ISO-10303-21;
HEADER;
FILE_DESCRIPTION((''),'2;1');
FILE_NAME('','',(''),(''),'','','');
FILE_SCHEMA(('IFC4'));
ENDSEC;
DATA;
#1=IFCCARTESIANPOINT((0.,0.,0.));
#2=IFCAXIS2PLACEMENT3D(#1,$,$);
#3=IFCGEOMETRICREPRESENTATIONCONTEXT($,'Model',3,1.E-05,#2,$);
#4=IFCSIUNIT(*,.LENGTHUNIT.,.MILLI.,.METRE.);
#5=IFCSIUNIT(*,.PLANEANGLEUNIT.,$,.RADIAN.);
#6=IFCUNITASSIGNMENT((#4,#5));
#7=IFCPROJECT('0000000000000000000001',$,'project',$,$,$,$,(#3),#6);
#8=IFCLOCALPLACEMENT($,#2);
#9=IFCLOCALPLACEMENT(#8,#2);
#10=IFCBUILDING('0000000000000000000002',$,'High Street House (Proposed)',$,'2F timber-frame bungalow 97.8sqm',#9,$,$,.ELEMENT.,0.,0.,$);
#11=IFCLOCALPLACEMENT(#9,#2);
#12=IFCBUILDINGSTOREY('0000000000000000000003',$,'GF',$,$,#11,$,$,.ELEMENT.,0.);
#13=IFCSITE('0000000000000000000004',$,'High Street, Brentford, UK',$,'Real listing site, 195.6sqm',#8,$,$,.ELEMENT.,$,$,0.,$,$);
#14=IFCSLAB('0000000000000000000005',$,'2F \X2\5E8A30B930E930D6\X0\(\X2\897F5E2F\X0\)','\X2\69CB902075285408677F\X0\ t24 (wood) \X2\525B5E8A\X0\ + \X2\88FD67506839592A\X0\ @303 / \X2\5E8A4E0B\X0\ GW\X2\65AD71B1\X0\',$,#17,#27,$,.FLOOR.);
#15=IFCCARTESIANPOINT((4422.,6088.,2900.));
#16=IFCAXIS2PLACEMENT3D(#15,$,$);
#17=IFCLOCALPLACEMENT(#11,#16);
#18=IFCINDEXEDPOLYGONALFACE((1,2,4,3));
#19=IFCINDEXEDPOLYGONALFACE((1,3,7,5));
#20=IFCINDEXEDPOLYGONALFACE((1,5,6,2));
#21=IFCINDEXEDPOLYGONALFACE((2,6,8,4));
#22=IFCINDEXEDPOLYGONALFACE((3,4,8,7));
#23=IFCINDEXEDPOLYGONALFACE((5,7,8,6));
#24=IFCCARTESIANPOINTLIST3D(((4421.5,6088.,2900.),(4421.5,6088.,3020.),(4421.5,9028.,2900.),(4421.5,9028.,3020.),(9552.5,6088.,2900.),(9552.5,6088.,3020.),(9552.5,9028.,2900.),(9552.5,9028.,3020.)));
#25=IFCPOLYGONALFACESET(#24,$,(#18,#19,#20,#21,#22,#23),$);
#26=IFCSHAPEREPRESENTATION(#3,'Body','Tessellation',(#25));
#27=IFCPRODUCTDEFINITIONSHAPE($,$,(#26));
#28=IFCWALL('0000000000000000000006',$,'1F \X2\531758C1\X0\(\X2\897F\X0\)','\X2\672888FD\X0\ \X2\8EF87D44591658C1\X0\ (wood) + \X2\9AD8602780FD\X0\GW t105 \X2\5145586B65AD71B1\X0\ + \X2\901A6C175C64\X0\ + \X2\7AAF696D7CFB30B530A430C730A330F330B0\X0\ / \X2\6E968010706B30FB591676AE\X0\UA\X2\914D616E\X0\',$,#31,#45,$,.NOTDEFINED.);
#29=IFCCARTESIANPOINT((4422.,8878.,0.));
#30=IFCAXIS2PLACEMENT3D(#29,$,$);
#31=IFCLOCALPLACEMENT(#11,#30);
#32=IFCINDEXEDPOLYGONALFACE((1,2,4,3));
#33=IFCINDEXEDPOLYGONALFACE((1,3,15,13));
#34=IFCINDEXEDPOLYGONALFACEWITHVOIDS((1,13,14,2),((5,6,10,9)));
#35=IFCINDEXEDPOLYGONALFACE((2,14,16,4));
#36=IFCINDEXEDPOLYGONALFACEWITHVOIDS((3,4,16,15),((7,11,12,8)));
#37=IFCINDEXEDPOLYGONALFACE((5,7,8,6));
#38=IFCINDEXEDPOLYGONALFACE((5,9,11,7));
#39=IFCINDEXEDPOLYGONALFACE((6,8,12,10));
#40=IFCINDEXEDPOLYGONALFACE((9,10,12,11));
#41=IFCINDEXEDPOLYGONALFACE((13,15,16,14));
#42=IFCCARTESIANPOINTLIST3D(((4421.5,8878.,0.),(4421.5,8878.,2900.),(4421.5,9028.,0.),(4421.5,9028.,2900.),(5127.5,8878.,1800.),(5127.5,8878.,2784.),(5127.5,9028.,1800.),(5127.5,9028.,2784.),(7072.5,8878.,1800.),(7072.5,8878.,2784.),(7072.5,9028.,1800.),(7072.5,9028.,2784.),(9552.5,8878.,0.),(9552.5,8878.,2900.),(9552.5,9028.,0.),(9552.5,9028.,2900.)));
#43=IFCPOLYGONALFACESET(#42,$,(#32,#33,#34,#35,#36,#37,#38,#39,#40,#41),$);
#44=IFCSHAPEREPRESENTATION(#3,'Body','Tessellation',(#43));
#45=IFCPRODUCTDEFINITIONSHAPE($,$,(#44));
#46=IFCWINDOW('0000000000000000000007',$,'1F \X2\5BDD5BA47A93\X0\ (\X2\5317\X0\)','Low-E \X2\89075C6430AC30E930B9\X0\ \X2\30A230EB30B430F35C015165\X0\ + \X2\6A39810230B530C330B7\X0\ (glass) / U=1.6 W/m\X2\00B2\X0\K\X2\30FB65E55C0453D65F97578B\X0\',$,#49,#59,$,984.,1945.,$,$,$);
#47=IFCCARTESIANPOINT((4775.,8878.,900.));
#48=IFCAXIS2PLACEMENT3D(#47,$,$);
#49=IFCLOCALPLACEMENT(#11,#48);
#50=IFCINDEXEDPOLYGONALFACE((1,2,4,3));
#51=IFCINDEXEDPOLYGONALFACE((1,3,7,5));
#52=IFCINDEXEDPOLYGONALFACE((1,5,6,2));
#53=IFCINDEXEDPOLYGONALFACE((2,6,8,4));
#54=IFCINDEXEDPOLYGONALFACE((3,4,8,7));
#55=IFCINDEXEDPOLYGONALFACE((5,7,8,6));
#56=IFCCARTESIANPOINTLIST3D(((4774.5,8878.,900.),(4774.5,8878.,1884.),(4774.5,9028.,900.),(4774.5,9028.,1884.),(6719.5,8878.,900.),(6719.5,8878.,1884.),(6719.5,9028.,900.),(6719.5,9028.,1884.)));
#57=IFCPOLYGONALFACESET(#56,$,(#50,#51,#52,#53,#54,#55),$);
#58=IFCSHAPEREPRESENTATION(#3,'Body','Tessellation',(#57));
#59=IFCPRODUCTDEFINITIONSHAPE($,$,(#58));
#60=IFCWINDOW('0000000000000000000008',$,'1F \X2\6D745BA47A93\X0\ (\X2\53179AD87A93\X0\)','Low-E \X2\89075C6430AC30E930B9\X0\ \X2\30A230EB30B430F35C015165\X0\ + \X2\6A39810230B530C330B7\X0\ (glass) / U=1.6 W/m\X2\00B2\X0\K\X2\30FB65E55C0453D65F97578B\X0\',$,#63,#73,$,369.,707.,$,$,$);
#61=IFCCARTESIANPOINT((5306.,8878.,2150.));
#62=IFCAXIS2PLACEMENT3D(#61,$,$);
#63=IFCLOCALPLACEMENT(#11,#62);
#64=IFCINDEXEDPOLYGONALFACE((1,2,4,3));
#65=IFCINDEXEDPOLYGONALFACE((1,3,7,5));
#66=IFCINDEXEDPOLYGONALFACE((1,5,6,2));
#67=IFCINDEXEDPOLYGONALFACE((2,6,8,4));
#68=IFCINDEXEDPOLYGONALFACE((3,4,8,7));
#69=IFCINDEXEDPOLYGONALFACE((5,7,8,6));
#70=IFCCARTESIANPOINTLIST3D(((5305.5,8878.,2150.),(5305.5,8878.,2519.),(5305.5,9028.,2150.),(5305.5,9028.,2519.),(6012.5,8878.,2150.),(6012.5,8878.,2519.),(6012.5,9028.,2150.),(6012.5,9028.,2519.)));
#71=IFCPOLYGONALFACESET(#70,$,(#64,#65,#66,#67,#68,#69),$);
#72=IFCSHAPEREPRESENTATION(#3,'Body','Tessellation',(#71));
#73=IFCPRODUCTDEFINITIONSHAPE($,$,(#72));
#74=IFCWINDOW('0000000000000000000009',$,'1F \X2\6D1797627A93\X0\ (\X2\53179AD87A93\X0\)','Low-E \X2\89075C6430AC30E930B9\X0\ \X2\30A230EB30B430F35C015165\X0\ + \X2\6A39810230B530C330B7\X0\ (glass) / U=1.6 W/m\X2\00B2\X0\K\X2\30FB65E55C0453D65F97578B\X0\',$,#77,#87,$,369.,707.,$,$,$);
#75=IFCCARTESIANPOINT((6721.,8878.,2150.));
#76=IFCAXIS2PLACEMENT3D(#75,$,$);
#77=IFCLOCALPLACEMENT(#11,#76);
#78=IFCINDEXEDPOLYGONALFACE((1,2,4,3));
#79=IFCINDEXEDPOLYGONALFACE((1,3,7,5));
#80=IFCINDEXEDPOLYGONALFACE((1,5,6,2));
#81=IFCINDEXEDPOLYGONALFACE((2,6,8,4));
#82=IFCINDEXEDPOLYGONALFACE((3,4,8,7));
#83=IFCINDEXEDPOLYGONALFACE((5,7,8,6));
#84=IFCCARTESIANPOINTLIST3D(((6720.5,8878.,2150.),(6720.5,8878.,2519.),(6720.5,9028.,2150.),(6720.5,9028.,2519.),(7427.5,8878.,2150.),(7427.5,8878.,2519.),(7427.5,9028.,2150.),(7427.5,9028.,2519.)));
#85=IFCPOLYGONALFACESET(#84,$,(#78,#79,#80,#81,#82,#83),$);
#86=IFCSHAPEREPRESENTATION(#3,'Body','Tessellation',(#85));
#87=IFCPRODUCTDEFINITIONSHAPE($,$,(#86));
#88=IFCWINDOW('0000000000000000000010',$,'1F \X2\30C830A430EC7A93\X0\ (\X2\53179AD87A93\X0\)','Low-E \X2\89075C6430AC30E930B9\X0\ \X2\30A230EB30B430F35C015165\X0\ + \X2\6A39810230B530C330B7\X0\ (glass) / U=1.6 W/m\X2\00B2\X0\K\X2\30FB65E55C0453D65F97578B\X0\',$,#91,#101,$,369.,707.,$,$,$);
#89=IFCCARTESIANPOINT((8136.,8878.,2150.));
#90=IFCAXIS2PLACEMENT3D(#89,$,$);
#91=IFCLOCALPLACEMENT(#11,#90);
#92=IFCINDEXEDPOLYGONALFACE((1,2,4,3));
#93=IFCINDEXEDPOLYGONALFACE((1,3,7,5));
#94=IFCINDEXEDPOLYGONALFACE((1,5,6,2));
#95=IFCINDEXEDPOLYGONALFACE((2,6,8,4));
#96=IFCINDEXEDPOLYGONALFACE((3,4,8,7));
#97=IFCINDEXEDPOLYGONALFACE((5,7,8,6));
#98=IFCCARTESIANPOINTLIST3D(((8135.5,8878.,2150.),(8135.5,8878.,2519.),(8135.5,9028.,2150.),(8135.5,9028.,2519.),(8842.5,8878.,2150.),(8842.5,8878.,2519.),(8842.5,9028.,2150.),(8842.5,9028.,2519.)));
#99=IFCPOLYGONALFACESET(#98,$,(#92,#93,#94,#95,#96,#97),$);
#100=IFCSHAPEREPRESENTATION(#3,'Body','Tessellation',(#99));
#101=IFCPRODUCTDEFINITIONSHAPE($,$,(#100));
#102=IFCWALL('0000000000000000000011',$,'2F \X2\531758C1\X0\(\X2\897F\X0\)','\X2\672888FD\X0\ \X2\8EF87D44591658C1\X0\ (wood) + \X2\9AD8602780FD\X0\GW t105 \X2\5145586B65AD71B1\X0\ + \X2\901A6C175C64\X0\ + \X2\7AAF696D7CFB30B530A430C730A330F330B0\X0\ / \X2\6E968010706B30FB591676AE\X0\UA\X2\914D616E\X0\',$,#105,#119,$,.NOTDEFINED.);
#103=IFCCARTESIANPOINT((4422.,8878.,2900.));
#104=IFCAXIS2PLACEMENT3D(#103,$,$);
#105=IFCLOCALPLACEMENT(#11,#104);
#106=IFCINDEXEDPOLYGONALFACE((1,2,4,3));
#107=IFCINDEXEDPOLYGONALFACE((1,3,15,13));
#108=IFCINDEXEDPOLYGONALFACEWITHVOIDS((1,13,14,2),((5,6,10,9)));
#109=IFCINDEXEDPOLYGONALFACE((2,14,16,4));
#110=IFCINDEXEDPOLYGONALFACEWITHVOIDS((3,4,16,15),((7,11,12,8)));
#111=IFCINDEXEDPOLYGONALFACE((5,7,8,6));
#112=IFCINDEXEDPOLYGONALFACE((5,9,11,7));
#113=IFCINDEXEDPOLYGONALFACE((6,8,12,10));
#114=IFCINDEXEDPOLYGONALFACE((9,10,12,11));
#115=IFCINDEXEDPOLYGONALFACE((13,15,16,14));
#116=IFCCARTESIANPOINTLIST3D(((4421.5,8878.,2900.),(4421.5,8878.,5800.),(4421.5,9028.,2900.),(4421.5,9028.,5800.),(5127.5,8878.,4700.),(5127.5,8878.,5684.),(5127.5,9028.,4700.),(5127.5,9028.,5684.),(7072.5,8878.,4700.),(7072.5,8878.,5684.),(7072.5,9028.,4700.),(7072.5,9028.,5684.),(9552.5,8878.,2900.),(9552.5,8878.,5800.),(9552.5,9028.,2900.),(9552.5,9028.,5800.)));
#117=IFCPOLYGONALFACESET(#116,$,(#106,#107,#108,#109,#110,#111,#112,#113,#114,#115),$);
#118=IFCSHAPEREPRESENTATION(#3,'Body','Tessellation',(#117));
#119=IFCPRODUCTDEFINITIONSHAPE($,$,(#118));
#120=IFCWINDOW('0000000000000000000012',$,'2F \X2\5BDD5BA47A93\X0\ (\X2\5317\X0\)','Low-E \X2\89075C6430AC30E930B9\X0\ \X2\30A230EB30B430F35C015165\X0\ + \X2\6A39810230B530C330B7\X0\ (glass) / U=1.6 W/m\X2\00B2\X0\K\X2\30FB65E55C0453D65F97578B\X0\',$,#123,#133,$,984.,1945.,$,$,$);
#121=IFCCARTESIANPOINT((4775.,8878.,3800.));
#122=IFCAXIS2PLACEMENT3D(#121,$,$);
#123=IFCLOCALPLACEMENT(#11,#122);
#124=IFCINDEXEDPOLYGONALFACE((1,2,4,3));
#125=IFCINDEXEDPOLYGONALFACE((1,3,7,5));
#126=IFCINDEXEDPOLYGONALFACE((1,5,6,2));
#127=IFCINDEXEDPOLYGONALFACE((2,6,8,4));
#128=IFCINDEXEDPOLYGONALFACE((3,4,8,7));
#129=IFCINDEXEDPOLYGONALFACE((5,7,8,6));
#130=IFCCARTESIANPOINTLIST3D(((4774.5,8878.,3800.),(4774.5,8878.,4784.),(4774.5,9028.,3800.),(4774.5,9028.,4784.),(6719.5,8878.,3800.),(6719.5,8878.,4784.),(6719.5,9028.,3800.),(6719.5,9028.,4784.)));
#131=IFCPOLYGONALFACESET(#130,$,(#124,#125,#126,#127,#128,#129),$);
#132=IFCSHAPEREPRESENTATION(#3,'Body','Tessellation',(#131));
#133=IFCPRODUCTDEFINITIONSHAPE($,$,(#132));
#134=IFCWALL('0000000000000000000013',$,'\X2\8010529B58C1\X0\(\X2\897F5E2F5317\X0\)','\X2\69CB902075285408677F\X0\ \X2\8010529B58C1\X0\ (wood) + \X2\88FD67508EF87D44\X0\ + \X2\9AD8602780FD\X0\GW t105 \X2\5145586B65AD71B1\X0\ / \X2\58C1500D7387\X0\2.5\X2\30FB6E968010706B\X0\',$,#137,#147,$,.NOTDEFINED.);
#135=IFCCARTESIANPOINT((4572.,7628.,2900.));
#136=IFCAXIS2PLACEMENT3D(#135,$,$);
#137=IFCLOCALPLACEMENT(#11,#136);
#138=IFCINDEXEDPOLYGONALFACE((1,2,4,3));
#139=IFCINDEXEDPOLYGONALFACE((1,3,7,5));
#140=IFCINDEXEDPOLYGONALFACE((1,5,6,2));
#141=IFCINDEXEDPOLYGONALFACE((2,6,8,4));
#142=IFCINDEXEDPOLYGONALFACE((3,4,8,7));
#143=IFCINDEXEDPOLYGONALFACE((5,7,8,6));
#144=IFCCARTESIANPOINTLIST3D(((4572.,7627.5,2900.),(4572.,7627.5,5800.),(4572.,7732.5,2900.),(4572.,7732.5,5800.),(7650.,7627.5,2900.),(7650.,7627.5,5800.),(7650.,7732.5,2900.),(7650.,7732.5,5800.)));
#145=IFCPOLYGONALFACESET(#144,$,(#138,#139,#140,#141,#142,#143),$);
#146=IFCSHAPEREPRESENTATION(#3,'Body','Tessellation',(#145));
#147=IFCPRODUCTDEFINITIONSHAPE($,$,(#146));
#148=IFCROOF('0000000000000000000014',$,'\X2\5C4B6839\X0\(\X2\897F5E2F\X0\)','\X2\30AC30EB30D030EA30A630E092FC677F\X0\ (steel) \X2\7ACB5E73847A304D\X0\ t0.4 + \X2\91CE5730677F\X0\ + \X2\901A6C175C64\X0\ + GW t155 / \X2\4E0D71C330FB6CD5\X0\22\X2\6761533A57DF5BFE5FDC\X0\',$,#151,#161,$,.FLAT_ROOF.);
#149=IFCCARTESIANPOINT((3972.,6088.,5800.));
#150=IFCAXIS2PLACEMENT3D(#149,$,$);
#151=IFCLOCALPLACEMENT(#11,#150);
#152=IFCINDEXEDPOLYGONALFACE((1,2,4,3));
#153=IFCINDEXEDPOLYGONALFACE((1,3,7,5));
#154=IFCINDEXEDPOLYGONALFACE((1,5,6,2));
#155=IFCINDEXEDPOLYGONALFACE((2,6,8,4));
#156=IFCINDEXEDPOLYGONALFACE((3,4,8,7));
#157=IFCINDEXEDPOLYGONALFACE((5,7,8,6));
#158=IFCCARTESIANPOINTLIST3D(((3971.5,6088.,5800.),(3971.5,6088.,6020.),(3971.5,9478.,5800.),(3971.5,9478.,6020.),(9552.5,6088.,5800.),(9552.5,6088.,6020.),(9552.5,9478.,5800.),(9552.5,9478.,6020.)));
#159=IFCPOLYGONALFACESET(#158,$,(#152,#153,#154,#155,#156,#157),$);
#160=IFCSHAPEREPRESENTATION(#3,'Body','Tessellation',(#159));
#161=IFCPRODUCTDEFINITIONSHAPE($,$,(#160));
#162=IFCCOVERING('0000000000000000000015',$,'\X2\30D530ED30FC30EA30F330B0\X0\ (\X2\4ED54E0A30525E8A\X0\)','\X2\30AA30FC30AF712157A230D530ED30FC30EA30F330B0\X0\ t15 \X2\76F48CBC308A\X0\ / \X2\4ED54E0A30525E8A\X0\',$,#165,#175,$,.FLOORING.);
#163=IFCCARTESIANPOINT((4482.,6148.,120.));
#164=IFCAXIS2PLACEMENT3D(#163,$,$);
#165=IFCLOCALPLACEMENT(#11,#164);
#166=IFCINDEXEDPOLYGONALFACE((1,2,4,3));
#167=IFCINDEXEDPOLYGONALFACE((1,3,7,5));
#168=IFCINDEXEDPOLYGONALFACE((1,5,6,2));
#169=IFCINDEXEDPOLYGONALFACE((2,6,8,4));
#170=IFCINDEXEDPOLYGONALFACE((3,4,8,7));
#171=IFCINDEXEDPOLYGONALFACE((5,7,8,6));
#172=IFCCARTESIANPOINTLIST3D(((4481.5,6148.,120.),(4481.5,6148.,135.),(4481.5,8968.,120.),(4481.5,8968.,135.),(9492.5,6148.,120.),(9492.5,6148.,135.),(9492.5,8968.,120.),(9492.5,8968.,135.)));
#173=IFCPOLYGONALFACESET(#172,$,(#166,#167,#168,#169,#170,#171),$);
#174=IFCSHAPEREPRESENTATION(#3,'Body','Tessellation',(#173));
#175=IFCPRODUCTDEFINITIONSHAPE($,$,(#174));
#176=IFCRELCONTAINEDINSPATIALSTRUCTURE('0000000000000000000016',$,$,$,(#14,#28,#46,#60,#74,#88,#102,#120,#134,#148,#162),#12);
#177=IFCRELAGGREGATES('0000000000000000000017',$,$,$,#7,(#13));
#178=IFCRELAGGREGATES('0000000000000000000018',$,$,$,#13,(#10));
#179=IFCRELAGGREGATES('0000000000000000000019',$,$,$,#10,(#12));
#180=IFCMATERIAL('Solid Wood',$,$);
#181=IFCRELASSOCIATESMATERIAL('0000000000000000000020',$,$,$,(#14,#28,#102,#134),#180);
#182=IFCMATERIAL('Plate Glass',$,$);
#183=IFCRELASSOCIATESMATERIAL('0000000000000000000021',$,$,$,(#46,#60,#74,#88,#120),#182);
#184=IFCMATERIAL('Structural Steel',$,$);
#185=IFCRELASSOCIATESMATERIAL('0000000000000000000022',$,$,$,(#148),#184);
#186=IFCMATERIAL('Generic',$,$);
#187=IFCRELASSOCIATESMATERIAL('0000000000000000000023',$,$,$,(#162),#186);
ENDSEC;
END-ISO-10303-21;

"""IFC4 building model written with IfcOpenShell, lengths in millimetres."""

from ifc_helpers import new_model, si_unit, frame, frame_2d, origin, place, context, project, spatial, rectangle, extrude, material, element, fill, save


model = new_model("IFC4")

# Units and contexts
model_context = context("Model", 3, precision=1e-05, world=origin())
ifc_project = project(units=[si_unit("LENGTHUNIT", "METRE", prefix="MILLI"), si_unit("PLANEANGLEUNIT", "RADIAN")], contexts=[model_context])

# Site, building, storey
site_placement = place(None, origin())
site = spatial("IfcSite", under=ifc_project, at=site_placement, Name="High Street, Brentford, UK", ObjectType="Real listing site, 195.6sqm", CompositionType="ELEMENT", RefElevation=0.0)
building_placement = place(site_placement, origin())
building = spatial("IfcBuilding", under=site, at=building_placement, Name="High Street House (Proposed)", ObjectType="2F timber-frame bungalow 97.8sqm", CompositionType="ELEMENT", ElevationOfRefHeight=0.0, ElevationOfTerrain=0.0)
storey_placement = place(building_placement, origin())
storey = spatial("IfcBuildingStorey", under=building, at=storey_placement, Name="GF", CompositionType="ELEMENT", Elevation=0.0)

# Slab
ifc_material_1 = material(Name="Solid Wood")
slab_1_placement = place(storey_placement, frame((4422.0, 6088.0, 2900.0)))
element("IfcSlab", 1, at=slab_1_placement, inside=storey, material=ifc_material_1, Name="2F 床スラブ(西帯)", Description="構造用合板 t24 (wood) 剛床 + 製材根太 @303 / 床下 GW断熱", PredefinedType="FLOOR", context=model_context, shape_type="SweptSolid", body=[
    extrude(rectangle(XDim=5131.0, YDim=2940.0, at=frame_2d((2565.0, 1470.0))), frame((4422.0, 6088.0, 2900.0)), (0.0, 0.0, 1.0), 120.0),
])

# Wall, openings, windows
wall_1_placement = place(storey_placement, frame((4422.0, 8878.0, 0.0)))
wall_1 = element("IfcWall", 2, at=wall_1_placement, inside=storey, material=ifc_material_1, Name="1F 北壁(西)", Description="木製 軸組外壁 (wood) + 高性能GW t105 充填断熱 + 通気層 + 窯業系サイディング / 準耐火・外皮UA配慮", PredefinedType="NOTDEFINED", context=model_context, shape_type="SweptSolid", body=[
    extrude(rectangle(XDim=5131.0, YDim=150.0, at=frame_2d((2565.0, 75.0))), frame((4422.0, 8878.0, 0.0)), (0.0, 0.0, 1.0), 2900.0),
])
opening_1_placement = place(storey_placement, frame((4775.0, 8878.0, 900.0)))
opening_1 = element("IfcOpeningElement", 3, at=opening_1_placement, cuts=wall_1, PredefinedType="NOTDEFINED", context=model_context, shape_type="SweptSolid", body=[
    extrude(rectangle(XDim=1945.0, YDim=150.0, at=frame_2d((972.0, 75.0))), frame((4775.0, 8878.0, 900.0)), (0.0, 0.0, 1.0), 984.0),
])
opening_2_placement = place(storey_placement, frame((5306.0, 8878.0, 2150.0)))
opening_2 = element("IfcOpeningElement", 4, at=opening_2_placement, cuts=wall_1, PredefinedType="NOTDEFINED", context=model_context, shape_type="SweptSolid", body=[
    extrude(rectangle(XDim=707.0, YDim=150.0, at=frame_2d((353.0, 75.0))), frame((5306.0, 8878.0, 2150.0)), (0.0, 0.0, 1.0), 369.0),
])
opening_3_placement = place(storey_placement, frame((6721.0, 8878.0, 2150.0)))
opening_3 = element("IfcOpeningElement", 5, at=opening_3_placement, cuts=wall_1, PredefinedType="NOTDEFINED", context=model_context, shape_type="SweptSolid", body=[
    extrude(rectangle(XDim=707.0, YDim=150.0, at=frame_2d((353.0, 75.0))), frame((6721.0, 8878.0, 2150.0)), (0.0, 0.0, 1.0), 369.0),
])
opening_4_placement = place(storey_placement, frame((8136.0, 8878.0, 2150.0)))
opening_4 = element("IfcOpeningElement", 6, at=opening_4_placement, cuts=wall_1, PredefinedType="NOTDEFINED", context=model_context, shape_type="SweptSolid", body=[
    extrude(rectangle(XDim=707.0, YDim=150.0, at=frame_2d((353.0, 75.0))), frame((8136.0, 8878.0, 2150.0)), (0.0, 0.0, 1.0), 369.0),
])
ifc_material_2 = material(Name="Plate Glass")
window_1_placement = place(storey_placement, frame((4775.0, 8878.0, 900.0)))
window_1 = element("IfcWindow", 7, at=window_1_placement, inside=storey, material=ifc_material_2, Name="1F 寝室窓 (北)", Description="Low-E 複層ガラス アルゴン封入 + 樹脂サッシ (glass) / U=1.6 W/m²K・日射取得型", OverallHeight=984.0, OverallWidth=1945.0, context=model_context, shape_type="SweptSolid", body=[
    extrude(rectangle(XDim=1945.0, YDim=150.0, at=frame_2d((972.0, 75.0))), frame((4775.0, 8878.0, 900.0)), (0.0, 0.0, 1.0), 984.0),
])
fill(opening_1, window_1)
window_2_placement = place(storey_placement, frame((5306.0, 8878.0, 2150.0)))
window_2 = element("IfcWindow", 8, at=window_2_placement, inside=storey, material=ifc_material_2, Name="1F 浴室窓 (北高窓)", Description="Low-E 複層ガラス アルゴン封入 + 樹脂サッシ (glass) / U=1.6 W/m²K・日射取得型", OverallHeight=369.0, OverallWidth=707.0, context=model_context, shape_type="SweptSolid", body=[
    extrude(rectangle(XDim=707.0, YDim=150.0, at=frame_2d((353.0, 75.0))), frame((5306.0, 8878.0, 2150.0)), (0.0, 0.0, 1.0), 369.0),
])
fill(opening_2, window_2)
window_3_placement = place(storey_placement, frame((6721.0, 8878.0, 2150.0)))
window_3 = element("IfcWindow", 9, at=window_3_placement, inside=storey, material=ifc_material_2, Name="1F 洗面窓 (北高窓)", Description="Low-E 複層ガラス アルゴン封入 + 樹脂サッシ (glass) / U=1.6 W/m²K・日射取得型", OverallHeight=369.0, OverallWidth=707.0, context=model_context, shape_type="SweptSolid", body=[
    extrude(rectangle(XDim=707.0, YDim=150.0, at=frame_2d((353.0, 75.0))), frame((6721.0, 8878.0, 2150.0)), (0.0, 0.0, 1.0), 369.0),
])
fill(opening_3, window_3)
window_4_placement = place(storey_placement, frame((8136.0, 8878.0, 2150.0)))
window_4 = element("IfcWindow", 10, at=window_4_placement, inside=storey, material=ifc_material_2, Name="1F トイレ窓 (北高窓)", Description="Low-E 複層ガラス アルゴン封入 + 樹脂サッシ (glass) / U=1.6 W/m²K・日射取得型", OverallHeight=369.0, OverallWidth=707.0, context=model_context, shape_type="SweptSolid", body=[
    extrude(rectangle(XDim=707.0, YDim=150.0, at=frame_2d((353.0, 75.0))), frame((8136.0, 8878.0, 2150.0)), (0.0, 0.0, 1.0), 369.0),
])
fill(opening_4, window_4)

# Wall, opening, window
wall_2_placement = place(storey_placement, frame((4422.0, 8878.0, 2900.0)))
wall_2 = element("IfcWall", 11, at=wall_2_placement, inside=storey, material=ifc_material_1, Name="2F 北壁(西)", Description="木製 軸組外壁 (wood) + 高性能GW t105 充填断熱 + 通気層 + 窯業系サイディング / 準耐火・外皮UA配慮", PredefinedType="NOTDEFINED", context=model_context, shape_type="SweptSolid", body=[
    extrude(rectangle(XDim=5131.0, YDim=150.0, at=frame_2d((2565.0, 75.0))), frame((4422.0, 8878.0, 2900.0)), (0.0, 0.0, 1.0), 2900.0),
])
opening_5_placement = place(storey_placement, frame((4775.0, 8878.0, 3800.0)))
opening_5 = element("IfcOpeningElement", 12, at=opening_5_placement, cuts=wall_2, PredefinedType="NOTDEFINED", context=model_context, shape_type="SweptSolid", body=[
    extrude(rectangle(XDim=1945.0, YDim=150.0, at=frame_2d((972.0, 75.0))), frame((4775.0, 8878.0, 3800.0)), (0.0, 0.0, 1.0), 984.0),
])
window_5_placement = place(storey_placement, frame((4775.0, 8878.0, 3800.0)))
window_5 = element("IfcWindow", 13, at=window_5_placement, inside=storey, material=ifc_material_2, Name="2F 寝室窓 (北)", Description="Low-E 複層ガラス アルゴン封入 + 樹脂サッシ (glass) / U=1.6 W/m²K・日射取得型", OverallHeight=984.0, OverallWidth=1945.0, context=model_context, shape_type="SweptSolid", body=[
    extrude(rectangle(XDim=1945.0, YDim=150.0, at=frame_2d((972.0, 75.0))), frame((4775.0, 8878.0, 3800.0)), (0.0, 0.0, 1.0), 984.0),
])
fill(opening_5, window_5)

# Wall
wall_3_placement = place(storey_placement, frame((4572.0, 7628.0, 2900.0)))
element("IfcWall", 14, at=wall_3_placement, inside=storey, material=ifc_material_1, Name="耐力壁(西帯北)", Description="構造用合板 耐力壁 (wood) + 製材軸組 + 高性能GW t105 充填断熱 / 壁倍率2.5・準耐火", PredefinedType="NOTDEFINED", context=model_context, shape_type="SweptSolid", body=[
    extrude(rectangle(XDim=3078.0, YDim=105.0, at=frame_2d((1539.0, 52.0))), frame((4572.0, 7628.0, 2900.0)), (0.0, 0.0, 1.0), 2900.0),
])

# Roof
ifc_material_3 = material(Name="Structural Steel")
for number, where, name in (
    (15, (3972.0, 6088.0, 5800.0), "屋根(西帯)"),
):
    element("IfcRoof", number, at=place(storey_placement, frame(where)), inside=storey, material=ifc_material_3, Name=name, Description="ガルバリウム鋼板 (steel) 立平葺き t0.4 + 野地板 + 通気層 + GW t155 / 不燃・法22条区域対応", PredefinedType="FLAT_ROOF", context=model_context, shape_type="SweptSolid", body=[
        extrude(rectangle(XDim=5581.0, YDim=3390.0, at=frame_2d((2790.0, 1695.0))), frame((3972.0, 6088.0, 5800.0)), (0.0, 0.0, 1.0), 220.0),
    ])

# Covering
ifc_material_4 = material(Name="Generic")
covering_1_placement = place(storey_placement, frame((4482.0, 6148.0, 120.0)))
element("IfcCovering", 16, at=covering_1_placement, inside=storey, material=ifc_material_4, Name="フローリング (仕上げ床)", Description="オーク無垢フローリング t15 直貼り / 仕上げ床", PredefinedType="FLOORING", context=model_context, shape_type="SweptSolid", body=[
    extrude(rectangle(XDim=5011.0, YDim=2820.0, at=frame_2d((2505.0, 1410.0))), frame((4482.0, 6148.0, 120.0)), (0.0, 0.0, 1.0), 15.0),
])

save(model, "model.ifc")
